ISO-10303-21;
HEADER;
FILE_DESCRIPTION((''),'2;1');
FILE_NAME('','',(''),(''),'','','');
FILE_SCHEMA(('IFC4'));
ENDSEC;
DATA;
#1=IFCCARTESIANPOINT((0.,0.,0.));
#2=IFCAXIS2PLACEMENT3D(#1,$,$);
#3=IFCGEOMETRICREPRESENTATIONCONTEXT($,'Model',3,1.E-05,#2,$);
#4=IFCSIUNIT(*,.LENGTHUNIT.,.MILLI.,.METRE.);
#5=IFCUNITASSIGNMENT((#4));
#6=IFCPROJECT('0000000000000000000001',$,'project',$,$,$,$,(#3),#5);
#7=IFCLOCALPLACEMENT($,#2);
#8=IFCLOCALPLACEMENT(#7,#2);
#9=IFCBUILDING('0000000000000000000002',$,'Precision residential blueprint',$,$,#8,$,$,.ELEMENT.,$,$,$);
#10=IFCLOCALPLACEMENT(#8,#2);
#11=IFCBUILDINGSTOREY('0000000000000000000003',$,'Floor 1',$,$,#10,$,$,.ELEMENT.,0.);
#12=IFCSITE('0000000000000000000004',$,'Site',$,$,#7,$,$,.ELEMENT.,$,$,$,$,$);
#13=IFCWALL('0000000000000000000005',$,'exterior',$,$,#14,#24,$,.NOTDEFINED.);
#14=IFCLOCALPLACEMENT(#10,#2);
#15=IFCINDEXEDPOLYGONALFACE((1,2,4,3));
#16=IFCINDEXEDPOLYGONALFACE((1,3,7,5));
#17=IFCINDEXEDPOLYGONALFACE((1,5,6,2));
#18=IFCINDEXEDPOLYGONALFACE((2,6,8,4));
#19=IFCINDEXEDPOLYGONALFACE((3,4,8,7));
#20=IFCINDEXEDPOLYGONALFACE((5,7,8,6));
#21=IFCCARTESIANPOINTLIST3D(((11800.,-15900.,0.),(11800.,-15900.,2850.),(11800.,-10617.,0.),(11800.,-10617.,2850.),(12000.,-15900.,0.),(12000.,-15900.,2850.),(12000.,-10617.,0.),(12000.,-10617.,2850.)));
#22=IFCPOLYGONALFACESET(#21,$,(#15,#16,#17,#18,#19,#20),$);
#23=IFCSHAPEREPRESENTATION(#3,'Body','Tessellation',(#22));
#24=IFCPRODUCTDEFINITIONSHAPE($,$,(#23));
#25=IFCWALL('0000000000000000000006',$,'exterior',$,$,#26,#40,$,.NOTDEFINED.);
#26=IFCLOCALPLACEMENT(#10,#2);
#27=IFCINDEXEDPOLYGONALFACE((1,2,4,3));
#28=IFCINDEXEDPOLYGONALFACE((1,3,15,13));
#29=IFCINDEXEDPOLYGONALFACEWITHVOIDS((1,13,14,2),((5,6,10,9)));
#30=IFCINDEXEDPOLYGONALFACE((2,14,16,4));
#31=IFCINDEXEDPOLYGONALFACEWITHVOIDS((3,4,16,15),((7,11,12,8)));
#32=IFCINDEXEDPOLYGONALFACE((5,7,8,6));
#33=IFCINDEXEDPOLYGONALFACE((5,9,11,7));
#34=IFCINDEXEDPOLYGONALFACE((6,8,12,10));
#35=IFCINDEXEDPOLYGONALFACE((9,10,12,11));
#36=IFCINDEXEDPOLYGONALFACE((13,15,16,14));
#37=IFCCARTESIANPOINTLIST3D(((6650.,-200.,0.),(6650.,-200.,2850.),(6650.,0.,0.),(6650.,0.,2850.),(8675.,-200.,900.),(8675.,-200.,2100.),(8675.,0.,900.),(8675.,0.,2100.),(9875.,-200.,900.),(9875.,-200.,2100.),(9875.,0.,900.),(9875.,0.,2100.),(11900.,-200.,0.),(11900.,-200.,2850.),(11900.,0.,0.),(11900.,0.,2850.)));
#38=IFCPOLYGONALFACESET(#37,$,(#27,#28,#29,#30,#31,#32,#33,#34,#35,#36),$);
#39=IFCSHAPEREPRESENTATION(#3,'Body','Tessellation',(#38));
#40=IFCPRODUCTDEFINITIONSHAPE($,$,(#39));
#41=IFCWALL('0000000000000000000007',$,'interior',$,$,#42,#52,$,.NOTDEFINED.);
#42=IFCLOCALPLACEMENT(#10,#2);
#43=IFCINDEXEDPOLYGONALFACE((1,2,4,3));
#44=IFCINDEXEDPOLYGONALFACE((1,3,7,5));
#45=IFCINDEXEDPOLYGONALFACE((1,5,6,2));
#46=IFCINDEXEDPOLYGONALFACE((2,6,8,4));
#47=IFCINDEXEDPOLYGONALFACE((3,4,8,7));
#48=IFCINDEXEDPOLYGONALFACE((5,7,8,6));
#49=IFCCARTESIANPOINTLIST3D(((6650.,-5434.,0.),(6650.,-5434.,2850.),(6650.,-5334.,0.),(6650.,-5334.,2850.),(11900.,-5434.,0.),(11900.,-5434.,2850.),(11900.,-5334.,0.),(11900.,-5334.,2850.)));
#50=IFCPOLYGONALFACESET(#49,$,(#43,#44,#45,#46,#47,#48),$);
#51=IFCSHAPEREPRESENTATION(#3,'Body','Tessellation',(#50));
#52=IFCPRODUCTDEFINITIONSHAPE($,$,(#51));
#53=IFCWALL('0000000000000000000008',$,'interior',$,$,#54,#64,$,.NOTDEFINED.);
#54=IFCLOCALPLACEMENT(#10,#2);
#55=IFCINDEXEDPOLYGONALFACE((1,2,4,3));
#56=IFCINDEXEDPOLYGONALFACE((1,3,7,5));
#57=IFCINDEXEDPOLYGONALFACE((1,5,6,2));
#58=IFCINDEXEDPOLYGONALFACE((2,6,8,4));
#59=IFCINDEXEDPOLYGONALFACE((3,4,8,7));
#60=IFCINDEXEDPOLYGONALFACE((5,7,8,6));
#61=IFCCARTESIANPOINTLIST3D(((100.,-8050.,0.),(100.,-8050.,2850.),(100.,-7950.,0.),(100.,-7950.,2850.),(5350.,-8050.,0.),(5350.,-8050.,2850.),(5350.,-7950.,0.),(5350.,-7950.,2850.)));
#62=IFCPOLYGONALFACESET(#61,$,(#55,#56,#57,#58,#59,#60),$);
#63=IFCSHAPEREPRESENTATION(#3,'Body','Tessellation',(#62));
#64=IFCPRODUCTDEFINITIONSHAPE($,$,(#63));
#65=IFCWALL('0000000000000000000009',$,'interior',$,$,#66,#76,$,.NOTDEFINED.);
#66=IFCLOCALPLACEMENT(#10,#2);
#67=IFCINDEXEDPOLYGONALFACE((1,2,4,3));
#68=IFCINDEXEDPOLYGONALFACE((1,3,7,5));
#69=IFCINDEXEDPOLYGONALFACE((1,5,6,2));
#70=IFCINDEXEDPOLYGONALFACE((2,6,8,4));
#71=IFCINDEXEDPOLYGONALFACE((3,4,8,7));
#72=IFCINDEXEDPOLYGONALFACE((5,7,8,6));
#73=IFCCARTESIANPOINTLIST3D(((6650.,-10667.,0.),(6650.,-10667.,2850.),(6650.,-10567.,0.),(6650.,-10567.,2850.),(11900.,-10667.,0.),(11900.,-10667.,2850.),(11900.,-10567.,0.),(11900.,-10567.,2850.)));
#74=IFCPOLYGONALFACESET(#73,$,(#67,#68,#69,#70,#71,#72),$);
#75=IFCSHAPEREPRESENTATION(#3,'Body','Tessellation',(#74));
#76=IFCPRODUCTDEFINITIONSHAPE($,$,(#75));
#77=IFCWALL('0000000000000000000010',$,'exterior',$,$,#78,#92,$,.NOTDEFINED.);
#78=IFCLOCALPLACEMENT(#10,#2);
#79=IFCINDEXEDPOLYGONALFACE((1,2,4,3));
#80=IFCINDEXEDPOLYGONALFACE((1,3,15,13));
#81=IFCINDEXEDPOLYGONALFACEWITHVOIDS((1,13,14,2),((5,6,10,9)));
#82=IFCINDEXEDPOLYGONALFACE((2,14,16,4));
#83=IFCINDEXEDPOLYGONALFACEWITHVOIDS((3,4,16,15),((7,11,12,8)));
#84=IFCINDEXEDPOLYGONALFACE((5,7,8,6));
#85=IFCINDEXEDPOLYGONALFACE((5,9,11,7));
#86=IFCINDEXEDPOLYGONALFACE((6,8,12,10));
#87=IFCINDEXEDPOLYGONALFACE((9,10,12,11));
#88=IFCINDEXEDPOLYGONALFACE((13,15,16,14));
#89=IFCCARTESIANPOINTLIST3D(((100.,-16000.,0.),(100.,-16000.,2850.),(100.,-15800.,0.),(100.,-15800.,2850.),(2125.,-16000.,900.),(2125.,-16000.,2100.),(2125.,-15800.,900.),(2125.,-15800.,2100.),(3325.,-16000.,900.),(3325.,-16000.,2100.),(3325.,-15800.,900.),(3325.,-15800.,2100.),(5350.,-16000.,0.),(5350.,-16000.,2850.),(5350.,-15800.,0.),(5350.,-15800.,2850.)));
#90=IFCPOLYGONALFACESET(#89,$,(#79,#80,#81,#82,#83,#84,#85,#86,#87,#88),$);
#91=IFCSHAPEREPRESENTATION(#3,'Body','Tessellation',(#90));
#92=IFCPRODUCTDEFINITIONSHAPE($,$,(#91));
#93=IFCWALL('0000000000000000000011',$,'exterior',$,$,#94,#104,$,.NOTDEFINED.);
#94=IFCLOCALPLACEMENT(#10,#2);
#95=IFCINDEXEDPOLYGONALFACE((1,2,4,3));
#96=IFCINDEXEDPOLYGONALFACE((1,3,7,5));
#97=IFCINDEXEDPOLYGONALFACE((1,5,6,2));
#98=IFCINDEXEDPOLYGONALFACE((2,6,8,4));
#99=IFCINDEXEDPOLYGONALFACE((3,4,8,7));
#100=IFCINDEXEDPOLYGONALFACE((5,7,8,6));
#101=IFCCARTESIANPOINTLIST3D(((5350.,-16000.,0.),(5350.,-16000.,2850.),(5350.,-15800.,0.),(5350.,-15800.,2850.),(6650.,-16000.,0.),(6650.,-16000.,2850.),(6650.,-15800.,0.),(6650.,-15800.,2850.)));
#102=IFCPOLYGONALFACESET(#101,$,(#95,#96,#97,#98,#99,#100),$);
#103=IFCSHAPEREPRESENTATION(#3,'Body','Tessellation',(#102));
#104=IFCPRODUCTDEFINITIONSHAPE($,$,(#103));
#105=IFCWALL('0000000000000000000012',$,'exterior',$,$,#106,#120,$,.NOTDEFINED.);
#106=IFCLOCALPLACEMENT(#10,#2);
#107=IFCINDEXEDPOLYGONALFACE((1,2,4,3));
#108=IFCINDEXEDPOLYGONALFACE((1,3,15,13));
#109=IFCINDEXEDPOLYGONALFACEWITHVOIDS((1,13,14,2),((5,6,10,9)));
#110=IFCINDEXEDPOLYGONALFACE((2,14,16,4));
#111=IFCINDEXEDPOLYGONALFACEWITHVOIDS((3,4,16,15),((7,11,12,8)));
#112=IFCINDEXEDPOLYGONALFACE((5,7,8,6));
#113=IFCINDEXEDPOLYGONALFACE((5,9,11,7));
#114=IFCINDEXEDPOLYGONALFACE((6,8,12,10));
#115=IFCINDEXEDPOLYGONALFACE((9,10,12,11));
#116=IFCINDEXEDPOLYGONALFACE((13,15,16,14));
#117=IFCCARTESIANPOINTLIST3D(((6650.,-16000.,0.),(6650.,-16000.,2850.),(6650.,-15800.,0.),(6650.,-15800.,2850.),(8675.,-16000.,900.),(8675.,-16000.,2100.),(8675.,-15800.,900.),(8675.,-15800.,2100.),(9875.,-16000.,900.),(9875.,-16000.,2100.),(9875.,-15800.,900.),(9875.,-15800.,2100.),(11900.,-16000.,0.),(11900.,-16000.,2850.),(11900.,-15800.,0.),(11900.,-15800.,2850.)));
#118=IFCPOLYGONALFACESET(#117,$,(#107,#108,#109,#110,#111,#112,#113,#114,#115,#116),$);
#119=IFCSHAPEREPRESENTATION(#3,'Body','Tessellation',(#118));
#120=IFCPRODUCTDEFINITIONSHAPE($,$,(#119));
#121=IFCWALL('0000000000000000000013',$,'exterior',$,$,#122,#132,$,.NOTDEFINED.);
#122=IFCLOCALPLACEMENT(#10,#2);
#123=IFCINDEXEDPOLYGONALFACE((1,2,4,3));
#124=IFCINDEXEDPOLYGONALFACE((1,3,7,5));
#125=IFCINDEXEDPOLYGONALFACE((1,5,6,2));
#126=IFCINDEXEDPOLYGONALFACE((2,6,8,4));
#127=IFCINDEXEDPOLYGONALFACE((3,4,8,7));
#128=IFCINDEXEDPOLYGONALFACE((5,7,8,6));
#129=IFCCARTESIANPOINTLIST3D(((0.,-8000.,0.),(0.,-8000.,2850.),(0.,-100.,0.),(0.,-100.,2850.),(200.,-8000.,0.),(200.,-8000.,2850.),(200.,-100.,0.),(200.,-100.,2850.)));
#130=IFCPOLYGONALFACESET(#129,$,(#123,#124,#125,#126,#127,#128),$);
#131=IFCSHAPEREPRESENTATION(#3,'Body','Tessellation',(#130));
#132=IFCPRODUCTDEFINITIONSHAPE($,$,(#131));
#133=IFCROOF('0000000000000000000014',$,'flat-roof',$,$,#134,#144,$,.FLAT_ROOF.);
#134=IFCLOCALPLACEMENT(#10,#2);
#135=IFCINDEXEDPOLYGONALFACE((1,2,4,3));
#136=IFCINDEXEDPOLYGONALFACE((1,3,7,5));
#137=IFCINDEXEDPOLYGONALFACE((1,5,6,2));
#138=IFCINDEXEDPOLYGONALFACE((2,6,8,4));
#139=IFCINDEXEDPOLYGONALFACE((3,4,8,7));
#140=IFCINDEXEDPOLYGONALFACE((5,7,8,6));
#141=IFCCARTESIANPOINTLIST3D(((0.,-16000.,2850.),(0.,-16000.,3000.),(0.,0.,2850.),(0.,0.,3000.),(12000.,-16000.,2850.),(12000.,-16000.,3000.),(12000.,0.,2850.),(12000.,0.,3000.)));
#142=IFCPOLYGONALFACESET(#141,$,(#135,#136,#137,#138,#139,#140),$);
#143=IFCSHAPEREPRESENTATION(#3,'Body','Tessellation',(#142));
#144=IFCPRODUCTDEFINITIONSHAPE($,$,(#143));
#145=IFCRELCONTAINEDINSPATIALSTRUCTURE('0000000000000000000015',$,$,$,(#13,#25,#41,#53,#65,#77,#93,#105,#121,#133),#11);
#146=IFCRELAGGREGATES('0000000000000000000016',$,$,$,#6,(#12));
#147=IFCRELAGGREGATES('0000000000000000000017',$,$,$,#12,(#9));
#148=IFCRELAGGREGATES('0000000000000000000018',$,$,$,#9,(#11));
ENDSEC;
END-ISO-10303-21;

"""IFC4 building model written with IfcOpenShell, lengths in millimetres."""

from ifc_helpers import new_model, si_unit, frame, origin, place, context, project, spatial, polyline, outline, extrude, element, save


model = new_model("IFC4")

# Units and contexts
model_context = context("Model", 3, precision=1e-05, world=origin())
ifc_project = project(units=[si_unit("LENGTHUNIT", "METRE", prefix="MILLI")], contexts=[model_context])

# Site, building, storey
site_placement = place(None, origin())
site = spatial("IfcSite", under=ifc_project, at=site_placement, Name="Site", CompositionType="ELEMENT")
building_placement = place(site_placement, origin())
building = spatial("IfcBuilding", under=site, at=building_placement, Name="Precision residential blueprint", CompositionType="ELEMENT")
storey_placement = place(building_placement, origin())
storey = spatial("IfcBuildingStorey", under=building, at=storey_placement, Name="Floor 1", CompositionType="ELEMENT", Elevation=0.0)

# Wall
wall_1_placement = place(storey_placement, origin())
element("IfcWall", 1, at=wall_1_placement, inside=storey, Name="exterior", PredefinedType="NOTDEFINED", context=model_context, shape_type="SweptSolid", body=[
    extrude(outline(polyline([(12000.0, -10617.0), (12000.0, -15900.0), (11800.0, -15900.0), (11800.0, -10617.0), (12000.0, -10617.0)])), origin(), (0.0, 0.0, 1.0), 2850.0),
])

# Wall, opening
wall_2_placement = place(storey_placement, origin())
wall_2 = element("IfcWall", 2, at=wall_2_placement, inside=storey, Name="exterior", PredefinedType="NOTDEFINED", context=model_context, shape_type="SweptSolid", body=[
    extrude(outline(polyline([(6650.0, 0.0), (11900.0, 0.0), (11900.0, -200.0), (6650.0, -200.0), (6650.0, 0.0)])), origin(), (0.0, 0.0, 1.0), 2850.0),
])
opening_1_placement = place(storey_placement, origin())
element("IfcOpeningElement", 3, at=opening_1_placement, cuts=wall_2, PredefinedType="OPENING", context=model_context, shape_type="SweptSolid", body=[
    extrude(outline(polyline([(8675.0, 0.0), (9875.0, 0.0), (9875.0, -200.0), (8675.0, -200.0), (8675.0, 0.0)])), frame((0.0, 0.0, 900.0)), (0.0, 0.0, 1.0), 1200.0),
])

# Walls
wall_3_placement = place(storey_placement, origin())
element("IfcWall", 4, at=wall_3_placement, inside=storey, Name="interior", PredefinedType="NOTDEFINED", context=model_context, shape_type="SweptSolid", body=[
    extrude(outline(polyline([(6650.0, -5334.0), (11900.0, -5334.0), (11900.0, -5434.0), (6650.0, -5434.0), (6650.0, -5334.0)])), origin(), (0.0, 0.0, 1.0), 2850.0),
])
wall_4_placement = place(storey_placement, origin())
element("IfcWall", 5, at=wall_4_placement, inside=storey, Name="interior", PredefinedType="NOTDEFINED", context=model_context, shape_type="SweptSolid", body=[
    extrude(outline(polyline([(100.0, -7950.0), (5350.0, -7950.0), (5350.0, -8050.0), (100.0, -8050.0), (100.0, -7950.0)])), origin(), (0.0, 0.0, 1.0), 2850.0),
])
wall_5_placement = place(storey_placement, origin())
element("IfcWall", 6, at=wall_5_placement, inside=storey, Name="interior", PredefinedType="NOTDEFINED", context=model_context, shape_type="SweptSolid", body=[
    extrude(outline(polyline([(6650.0, -10567.0), (11900.0, -10567.0), (11900.0, -10667.0), (6650.0, -10667.0), (6650.0, -10567.0)])), origin(), (0.0, 0.0, 1.0), 2850.0),
])

# Wall, opening
wall_6_placement = place(storey_placement, origin())
wall_6 = element("IfcWall", 7, at=wall_6_placement, inside=storey, Name="exterior", PredefinedType="NOTDEFINED", context=model_context, shape_type="SweptSolid", body=[
    extrude(outline(polyline([(100.0, -15800.0), (5350.0, -15800.0), (5350.0, -16000.0), (100.0, -16000.0), (100.0, -15800.0)])), origin(), (0.0, 0.0, 1.0), 2850.0),
])
opening_2_placement = place(storey_placement, origin())
element("IfcOpeningElement", 8, at=opening_2_placement, cuts=wall_6, PredefinedType="OPENING", context=model_context, shape_type="SweptSolid", body=[
    extrude(outline(polyline([(2125.0, -15800.0), (3325.0, -15800.0), (3325.0, -16000.0), (2125.0, -16000.0), (2125.0, -15800.0)])), frame((0.0, 0.0, 900.0)), (0.0, 0.0, 1.0), 1200.0),
])

# Wall
wall_7_placement = place(storey_placement, origin())
element("IfcWall", 9, at=wall_7_placement, inside=storey, Name="exterior", PredefinedType="NOTDEFINED", context=model_context, shape_type="SweptSolid", body=[
    extrude(outline(polyline([(5350.0, -15800.0), (6650.0, -15800.0), (6650.0, -16000.0), (5350.0, -16000.0), (5350.0, -15800.0)])), origin(), (0.0, 0.0, 1.0), 2850.0),
])

# Wall, opening
wall_8_placement = place(storey_placement, origin())
wall_8 = element("IfcWall", 10, at=wall_8_placement, inside=storey, Name="exterior", PredefinedType="NOTDEFINED", context=model_context, shape_type="SweptSolid", body=[
    extrude(outline(polyline([(6650.0, -15800.0), (11900.0, -15800.0), (11900.0, -16000.0), (6650.0, -16000.0), (6650.0, -15800.0)])), origin(), (0.0, 0.0, 1.0), 2850.0),
])
opening_3_placement = place(storey_placement, origin())
element("IfcOpeningElement", 11, at=opening_3_placement, cuts=wall_8, PredefinedType="OPENING", context=model_context, shape_type="SweptSolid", body=[
    extrude(outline(polyline([(8675.0, -15800.0), (9875.0, -15800.0), (9875.0, -16000.0), (8675.0, -16000.0), (8675.0, -15800.0)])), frame((0.0, 0.0, 900.0)), (0.0, 0.0, 1.0), 1200.0),
])

# Wall
wall_9_placement = place(storey_placement, origin())
element("IfcWall", 12, at=wall_9_placement, inside=storey, Name="exterior", PredefinedType="NOTDEFINED", context=model_context, shape_type="SweptSolid", body=[
    extrude(outline(polyline([(200.0, -100.0), (200.0, -8000.0), (0.0, -8000.0), (0.0, -100.0), (200.0, -100.0)])), origin(), (0.0, 0.0, 1.0), 2850.0),
])

# Roof
roof_placement = place(storey_placement, origin())
element("IfcRoof", 13, at=roof_placement, inside=storey, Name="flat-roof", PredefinedType="FLAT_ROOF", context=model_context, shape_type="SweptSolid", body=[
    extrude(outline(polyline([(0.0, -16000.0), (12000.0, -16000.0), (12000.0, 0.0), (0.0, 0.0), (0.0, -16000.0)])), frame((0.0, 0.0, 2850.0)), (0.0, 0.0, 1.0), 150.0),
])

save(model, "model.ifc")
